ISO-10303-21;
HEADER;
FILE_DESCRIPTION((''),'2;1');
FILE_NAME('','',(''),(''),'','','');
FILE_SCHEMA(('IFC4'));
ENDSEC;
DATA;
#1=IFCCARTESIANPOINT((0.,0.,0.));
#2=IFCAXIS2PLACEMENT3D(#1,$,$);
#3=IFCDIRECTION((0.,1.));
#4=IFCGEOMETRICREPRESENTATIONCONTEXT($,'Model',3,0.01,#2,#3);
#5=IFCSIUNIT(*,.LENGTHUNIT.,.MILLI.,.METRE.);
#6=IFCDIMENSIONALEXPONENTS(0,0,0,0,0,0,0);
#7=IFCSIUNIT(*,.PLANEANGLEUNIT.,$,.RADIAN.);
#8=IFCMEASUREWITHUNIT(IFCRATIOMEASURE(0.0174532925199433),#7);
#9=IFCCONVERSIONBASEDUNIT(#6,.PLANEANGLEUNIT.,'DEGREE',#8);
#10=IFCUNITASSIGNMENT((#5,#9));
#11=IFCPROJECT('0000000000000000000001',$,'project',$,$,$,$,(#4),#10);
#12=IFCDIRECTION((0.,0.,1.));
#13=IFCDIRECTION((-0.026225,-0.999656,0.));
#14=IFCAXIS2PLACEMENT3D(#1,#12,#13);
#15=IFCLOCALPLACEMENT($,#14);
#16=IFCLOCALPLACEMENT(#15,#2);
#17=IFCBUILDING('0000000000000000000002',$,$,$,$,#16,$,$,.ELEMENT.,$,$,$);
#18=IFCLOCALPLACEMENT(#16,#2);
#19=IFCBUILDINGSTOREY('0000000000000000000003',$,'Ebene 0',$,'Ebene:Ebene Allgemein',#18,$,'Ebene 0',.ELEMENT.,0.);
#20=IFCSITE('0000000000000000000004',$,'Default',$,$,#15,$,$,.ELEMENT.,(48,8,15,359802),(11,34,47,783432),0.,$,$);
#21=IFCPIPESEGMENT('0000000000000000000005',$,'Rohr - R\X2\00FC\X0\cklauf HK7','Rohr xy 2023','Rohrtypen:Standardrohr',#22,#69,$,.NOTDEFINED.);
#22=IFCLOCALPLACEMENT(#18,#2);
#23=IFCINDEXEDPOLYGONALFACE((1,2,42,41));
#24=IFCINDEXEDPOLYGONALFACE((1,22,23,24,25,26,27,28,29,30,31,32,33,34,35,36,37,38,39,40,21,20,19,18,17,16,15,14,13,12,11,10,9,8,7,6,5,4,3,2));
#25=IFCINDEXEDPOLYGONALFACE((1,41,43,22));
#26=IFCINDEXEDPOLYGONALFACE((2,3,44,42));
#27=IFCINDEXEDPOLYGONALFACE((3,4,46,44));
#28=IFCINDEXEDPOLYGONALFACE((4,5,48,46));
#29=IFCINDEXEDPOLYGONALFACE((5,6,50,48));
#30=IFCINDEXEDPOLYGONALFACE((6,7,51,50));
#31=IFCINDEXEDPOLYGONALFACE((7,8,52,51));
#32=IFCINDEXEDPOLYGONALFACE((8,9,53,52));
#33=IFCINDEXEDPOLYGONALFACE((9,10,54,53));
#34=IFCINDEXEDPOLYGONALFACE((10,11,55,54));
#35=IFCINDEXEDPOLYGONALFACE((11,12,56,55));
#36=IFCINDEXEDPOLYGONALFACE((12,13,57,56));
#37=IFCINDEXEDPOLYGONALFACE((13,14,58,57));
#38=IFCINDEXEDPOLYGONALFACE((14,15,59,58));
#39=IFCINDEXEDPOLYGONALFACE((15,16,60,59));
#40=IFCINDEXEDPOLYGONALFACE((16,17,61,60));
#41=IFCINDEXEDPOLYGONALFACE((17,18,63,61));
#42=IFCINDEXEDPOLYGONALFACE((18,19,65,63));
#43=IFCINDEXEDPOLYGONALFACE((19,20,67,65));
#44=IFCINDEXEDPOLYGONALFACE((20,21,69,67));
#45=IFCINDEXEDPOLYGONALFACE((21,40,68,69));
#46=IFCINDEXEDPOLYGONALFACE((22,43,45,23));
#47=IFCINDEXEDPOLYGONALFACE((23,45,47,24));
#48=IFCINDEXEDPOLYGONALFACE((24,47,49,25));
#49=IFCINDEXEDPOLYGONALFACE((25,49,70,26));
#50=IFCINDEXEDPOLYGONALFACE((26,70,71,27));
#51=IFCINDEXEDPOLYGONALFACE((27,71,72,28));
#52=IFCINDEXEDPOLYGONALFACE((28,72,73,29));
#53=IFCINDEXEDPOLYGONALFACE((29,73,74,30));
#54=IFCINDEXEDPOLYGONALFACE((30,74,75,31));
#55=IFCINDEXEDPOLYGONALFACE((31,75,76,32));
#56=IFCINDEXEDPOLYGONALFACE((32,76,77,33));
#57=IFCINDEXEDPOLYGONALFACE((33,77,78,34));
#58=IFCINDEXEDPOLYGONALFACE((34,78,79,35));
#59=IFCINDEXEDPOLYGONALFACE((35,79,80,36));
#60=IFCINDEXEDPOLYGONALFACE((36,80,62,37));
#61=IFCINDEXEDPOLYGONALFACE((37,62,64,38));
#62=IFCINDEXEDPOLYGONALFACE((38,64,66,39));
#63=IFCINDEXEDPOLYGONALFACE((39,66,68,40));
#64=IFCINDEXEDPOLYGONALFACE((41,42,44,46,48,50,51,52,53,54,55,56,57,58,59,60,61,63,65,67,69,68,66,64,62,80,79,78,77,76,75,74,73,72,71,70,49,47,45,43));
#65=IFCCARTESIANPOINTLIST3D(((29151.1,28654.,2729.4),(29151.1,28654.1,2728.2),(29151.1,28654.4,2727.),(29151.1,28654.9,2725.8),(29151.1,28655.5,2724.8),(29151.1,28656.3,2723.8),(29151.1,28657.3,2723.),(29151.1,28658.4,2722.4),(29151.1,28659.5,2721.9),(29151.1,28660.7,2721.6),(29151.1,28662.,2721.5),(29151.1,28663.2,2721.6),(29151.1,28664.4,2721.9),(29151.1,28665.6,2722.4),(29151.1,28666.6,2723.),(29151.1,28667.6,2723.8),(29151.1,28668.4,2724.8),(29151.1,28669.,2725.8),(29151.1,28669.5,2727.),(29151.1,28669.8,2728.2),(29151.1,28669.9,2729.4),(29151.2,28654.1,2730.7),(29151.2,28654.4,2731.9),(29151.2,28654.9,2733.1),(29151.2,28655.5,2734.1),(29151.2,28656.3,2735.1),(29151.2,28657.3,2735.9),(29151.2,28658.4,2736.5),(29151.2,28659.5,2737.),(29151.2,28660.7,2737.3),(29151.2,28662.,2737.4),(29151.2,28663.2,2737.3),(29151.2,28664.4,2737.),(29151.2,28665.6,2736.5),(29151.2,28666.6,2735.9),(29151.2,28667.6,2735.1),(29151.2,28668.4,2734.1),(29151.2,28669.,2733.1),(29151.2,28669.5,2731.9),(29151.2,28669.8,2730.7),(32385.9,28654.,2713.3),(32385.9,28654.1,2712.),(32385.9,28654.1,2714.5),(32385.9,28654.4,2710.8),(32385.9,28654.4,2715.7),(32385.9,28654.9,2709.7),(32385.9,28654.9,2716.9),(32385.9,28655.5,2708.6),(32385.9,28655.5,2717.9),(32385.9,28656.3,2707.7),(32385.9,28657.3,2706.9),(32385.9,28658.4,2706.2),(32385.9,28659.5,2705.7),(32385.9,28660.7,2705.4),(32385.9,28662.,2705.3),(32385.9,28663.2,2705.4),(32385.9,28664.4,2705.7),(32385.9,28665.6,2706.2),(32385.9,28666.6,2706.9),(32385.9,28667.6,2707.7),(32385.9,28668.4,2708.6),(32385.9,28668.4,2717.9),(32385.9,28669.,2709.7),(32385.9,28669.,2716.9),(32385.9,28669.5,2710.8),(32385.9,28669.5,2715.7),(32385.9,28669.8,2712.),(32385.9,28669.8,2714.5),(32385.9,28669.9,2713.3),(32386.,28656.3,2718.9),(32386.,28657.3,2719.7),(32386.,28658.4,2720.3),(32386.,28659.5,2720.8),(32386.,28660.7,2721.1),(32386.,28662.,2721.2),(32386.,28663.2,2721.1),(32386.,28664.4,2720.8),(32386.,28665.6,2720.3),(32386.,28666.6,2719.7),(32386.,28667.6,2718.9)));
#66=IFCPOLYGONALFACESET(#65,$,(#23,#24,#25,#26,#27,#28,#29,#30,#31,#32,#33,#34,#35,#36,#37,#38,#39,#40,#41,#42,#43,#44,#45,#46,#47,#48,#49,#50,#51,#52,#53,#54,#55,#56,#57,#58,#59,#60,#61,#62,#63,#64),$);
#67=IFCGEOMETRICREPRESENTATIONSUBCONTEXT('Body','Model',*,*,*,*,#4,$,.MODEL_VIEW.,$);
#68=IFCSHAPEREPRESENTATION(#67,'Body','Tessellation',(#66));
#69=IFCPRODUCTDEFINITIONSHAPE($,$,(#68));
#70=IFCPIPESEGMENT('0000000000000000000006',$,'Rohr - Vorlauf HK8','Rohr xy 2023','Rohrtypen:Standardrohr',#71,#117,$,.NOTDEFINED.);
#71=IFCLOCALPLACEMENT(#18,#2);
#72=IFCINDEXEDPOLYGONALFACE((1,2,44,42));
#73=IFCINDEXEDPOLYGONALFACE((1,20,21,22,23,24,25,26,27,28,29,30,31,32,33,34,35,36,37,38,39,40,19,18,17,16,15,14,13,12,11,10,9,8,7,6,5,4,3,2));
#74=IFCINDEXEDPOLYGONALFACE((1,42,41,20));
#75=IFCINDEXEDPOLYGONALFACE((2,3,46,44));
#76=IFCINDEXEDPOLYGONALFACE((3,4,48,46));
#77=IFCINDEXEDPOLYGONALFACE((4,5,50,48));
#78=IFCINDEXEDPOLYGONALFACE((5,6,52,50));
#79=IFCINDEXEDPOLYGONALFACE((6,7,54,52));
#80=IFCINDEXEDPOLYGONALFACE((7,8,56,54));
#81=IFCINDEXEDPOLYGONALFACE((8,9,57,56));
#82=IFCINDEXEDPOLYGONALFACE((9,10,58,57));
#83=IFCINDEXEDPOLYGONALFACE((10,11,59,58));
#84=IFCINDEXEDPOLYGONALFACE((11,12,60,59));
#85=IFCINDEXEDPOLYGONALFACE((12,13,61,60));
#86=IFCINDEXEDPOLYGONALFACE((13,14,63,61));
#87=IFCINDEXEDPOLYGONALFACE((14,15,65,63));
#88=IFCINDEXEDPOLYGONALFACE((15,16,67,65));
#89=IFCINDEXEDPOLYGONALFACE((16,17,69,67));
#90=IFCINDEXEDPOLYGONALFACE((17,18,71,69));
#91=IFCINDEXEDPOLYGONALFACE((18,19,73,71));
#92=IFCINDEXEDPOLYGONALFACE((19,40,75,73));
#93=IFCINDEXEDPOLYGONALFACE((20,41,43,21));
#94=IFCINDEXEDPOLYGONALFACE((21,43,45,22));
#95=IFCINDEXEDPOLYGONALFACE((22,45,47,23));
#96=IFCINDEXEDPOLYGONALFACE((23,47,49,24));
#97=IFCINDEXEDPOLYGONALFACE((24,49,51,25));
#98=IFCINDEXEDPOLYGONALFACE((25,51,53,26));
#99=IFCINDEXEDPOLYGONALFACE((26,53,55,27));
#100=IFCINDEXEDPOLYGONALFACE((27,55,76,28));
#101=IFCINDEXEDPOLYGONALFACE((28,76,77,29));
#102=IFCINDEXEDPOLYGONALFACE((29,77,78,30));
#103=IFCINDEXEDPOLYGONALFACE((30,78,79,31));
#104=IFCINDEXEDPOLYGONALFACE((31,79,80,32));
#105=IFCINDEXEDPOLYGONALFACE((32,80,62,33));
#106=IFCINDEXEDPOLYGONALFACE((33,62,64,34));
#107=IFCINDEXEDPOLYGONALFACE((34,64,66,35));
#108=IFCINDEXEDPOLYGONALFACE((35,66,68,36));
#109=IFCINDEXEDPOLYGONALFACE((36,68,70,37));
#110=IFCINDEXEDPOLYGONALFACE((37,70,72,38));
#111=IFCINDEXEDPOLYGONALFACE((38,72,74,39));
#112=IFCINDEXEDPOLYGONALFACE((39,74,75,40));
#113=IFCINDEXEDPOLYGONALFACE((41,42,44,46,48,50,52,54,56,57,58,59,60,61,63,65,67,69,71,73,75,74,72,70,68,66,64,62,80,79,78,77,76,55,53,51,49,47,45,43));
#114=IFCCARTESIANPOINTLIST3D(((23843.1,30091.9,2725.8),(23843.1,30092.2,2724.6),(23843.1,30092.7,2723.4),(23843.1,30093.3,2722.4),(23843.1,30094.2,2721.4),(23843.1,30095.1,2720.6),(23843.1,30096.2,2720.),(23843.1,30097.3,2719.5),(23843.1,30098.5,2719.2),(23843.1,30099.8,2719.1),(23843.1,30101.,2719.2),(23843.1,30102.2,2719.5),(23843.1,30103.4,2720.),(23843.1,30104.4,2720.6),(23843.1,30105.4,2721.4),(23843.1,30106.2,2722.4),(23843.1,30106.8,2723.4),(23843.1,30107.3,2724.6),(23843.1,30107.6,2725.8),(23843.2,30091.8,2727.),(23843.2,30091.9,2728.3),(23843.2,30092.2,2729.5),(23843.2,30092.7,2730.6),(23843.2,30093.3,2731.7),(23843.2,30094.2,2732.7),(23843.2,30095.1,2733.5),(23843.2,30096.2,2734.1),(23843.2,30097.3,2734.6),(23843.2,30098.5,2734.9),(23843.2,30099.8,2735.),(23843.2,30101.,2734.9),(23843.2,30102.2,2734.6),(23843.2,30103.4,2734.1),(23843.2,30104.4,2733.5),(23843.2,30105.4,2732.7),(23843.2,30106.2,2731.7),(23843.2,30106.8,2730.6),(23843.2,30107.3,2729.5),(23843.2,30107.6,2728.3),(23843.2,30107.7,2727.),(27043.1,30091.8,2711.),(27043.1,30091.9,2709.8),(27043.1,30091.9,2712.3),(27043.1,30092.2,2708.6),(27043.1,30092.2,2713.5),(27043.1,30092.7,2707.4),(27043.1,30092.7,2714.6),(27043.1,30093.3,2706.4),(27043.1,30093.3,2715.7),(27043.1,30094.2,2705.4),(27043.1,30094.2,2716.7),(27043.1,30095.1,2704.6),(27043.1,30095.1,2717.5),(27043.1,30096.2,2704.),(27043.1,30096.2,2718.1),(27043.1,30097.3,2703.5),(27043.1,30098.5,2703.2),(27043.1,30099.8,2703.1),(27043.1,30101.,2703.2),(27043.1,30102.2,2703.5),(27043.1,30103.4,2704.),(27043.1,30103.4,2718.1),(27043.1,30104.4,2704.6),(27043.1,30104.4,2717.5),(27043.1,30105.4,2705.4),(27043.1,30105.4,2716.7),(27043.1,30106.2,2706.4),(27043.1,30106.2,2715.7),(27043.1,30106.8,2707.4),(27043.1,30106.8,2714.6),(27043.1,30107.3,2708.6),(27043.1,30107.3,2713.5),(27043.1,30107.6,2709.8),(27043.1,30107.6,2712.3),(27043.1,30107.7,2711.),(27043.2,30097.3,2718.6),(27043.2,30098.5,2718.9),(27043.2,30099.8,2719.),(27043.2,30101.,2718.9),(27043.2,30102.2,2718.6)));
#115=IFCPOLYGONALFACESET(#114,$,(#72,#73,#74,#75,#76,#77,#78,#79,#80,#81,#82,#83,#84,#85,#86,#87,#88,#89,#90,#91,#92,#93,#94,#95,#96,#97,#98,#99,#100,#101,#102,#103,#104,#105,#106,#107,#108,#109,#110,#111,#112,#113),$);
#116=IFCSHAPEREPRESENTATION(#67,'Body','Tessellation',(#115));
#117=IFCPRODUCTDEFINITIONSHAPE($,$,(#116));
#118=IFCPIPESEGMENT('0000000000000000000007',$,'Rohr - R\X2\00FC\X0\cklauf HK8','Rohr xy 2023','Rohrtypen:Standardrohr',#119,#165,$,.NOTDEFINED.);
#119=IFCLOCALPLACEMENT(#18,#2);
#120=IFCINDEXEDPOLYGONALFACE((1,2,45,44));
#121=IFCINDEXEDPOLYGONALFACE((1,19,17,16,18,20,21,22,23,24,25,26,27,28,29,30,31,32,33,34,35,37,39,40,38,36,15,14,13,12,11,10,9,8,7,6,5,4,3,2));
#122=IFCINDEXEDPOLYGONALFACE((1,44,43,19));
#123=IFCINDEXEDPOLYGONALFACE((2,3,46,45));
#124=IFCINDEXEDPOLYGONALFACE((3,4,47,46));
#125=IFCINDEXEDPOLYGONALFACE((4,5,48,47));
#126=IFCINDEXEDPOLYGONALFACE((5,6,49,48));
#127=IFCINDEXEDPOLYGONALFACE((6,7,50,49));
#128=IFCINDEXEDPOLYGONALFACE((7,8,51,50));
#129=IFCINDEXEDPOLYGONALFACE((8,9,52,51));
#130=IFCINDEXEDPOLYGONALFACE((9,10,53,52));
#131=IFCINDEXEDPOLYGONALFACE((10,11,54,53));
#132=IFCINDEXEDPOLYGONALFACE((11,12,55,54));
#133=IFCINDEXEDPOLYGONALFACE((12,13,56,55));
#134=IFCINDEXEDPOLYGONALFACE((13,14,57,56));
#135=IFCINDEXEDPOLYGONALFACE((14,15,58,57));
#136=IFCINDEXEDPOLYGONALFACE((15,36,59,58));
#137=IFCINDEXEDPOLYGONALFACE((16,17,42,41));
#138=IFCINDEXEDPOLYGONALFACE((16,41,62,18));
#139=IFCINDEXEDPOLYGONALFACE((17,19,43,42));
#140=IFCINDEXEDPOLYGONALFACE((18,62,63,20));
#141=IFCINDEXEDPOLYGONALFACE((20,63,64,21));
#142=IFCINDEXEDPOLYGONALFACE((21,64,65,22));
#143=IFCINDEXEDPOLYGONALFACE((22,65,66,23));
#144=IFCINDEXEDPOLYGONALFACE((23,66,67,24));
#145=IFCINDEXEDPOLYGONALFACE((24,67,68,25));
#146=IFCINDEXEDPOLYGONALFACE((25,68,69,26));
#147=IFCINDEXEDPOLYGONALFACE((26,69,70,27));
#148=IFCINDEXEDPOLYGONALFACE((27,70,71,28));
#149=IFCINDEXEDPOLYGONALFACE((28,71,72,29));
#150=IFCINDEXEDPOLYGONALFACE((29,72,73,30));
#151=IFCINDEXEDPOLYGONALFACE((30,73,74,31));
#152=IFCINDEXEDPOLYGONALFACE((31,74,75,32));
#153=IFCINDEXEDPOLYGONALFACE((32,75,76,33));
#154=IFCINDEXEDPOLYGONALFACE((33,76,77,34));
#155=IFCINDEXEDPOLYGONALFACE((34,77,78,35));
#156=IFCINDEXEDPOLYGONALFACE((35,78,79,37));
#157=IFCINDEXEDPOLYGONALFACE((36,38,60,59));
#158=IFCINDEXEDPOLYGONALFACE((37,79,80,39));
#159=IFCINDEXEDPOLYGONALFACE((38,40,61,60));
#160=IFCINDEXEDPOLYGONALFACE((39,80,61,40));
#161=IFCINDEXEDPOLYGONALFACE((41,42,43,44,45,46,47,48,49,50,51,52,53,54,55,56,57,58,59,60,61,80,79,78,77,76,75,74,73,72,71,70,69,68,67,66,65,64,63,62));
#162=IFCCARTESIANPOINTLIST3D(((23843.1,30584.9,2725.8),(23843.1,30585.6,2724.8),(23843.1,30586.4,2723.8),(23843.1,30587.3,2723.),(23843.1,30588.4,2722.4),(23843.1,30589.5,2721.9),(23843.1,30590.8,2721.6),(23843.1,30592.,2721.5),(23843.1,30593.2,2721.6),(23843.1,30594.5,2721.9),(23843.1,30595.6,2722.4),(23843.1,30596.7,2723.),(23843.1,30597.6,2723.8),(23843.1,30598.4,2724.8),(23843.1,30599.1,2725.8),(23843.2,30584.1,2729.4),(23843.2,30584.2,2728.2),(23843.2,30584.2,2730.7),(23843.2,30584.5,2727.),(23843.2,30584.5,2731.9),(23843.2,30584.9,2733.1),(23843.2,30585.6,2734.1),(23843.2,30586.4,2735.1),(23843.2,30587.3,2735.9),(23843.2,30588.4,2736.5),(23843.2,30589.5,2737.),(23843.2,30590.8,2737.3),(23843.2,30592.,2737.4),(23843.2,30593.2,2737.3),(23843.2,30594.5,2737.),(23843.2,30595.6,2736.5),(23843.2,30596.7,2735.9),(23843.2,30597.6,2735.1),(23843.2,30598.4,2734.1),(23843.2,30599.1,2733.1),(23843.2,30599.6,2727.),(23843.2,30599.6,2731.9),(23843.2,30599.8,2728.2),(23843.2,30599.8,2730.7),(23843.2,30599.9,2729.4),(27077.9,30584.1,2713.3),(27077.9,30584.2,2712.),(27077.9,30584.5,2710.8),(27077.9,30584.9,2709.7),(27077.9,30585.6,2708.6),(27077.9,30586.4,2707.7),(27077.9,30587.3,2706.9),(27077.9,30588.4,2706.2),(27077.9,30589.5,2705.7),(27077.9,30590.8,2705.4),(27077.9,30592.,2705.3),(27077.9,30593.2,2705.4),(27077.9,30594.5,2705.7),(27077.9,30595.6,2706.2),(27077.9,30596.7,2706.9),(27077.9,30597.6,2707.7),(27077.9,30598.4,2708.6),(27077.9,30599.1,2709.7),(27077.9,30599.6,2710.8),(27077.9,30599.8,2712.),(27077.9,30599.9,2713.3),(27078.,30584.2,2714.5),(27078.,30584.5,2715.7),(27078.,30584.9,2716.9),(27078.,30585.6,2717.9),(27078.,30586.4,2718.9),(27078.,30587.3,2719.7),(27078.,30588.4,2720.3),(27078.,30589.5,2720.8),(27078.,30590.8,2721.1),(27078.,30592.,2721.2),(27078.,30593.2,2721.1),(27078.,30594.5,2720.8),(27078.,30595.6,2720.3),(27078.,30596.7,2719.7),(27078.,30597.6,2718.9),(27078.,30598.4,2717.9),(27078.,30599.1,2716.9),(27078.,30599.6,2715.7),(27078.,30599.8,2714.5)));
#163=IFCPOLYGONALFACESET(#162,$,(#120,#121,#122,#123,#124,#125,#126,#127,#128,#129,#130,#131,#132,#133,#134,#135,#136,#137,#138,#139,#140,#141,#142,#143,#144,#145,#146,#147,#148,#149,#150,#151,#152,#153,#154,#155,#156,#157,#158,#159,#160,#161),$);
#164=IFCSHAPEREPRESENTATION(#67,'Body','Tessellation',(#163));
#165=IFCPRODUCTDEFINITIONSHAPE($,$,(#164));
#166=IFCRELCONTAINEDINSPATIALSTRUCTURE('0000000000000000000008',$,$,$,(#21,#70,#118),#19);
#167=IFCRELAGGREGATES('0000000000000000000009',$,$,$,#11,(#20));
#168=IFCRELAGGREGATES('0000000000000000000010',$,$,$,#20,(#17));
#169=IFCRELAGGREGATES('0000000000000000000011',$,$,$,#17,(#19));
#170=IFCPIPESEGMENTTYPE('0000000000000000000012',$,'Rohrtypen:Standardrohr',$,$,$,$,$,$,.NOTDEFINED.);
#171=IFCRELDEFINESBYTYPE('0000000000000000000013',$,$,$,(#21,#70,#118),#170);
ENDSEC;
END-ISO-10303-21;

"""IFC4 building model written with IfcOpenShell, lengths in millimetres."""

from ifc_helpers import new_model, entity, si_unit, converted_unit, direction, frame, origin, place, context, subcontext, project, spatial, indexed_curve, outline, extrude, type_object, element, save


model = new_model("IFC4")

# Units and contexts
model_context = context("Model", 3, precision=0.01, world=origin(), true_north=direction((0.0, 1.0)))
body_context = subcontext(model_context, "Body", "Model", "MODEL_VIEW")
ifc_project = project(units=[si_unit("LENGTHUNIT", "METRE", prefix="MILLI"), converted_unit("PLANEANGLEUNIT", "DEGREE", entity("IfcRatioMeasure", 0.0174532925199433), si_unit("PLANEANGLEUNIT", "RADIAN"), dimensions=[0, 0, 0, 0, 0, 0, 0])], contexts=[model_context])

# Site, building, storey
site_placement = place(None, frame((0.0, 0.0, 0.0), z_axis=(0.0, 0.0, 1.0), x_axis=(-0.026225, -0.999656, 0.0)))
site = spatial("IfcSite", under=ifc_project, at=site_placement, Name="Default", CompositionType="ELEMENT", RefLatitude=(48, 8, 15, 359802), RefLongitude=(11, 34, 47, 783432), RefElevation=0.0)
building_placement = place(site_placement, origin())
building = spatial("IfcBuilding", under=site, at=building_placement, CompositionType="ELEMENT")
storey_placement = place(building_placement, origin())
storey = spatial("IfcBuildingStorey", under=building, at=storey_placement, Name="Ebene 0", ObjectType="Ebene:Ebene Allgemein", LongName="Ebene 0", CompositionType="ELEMENT", Elevation=0.0)

# Pipe segments
pipe_segment_type = type_object("IfcPipeSegmentType", Name="Rohrtypen:Standardrohr", PredefinedType="NOTDEFINED")
pipe_segment_1_placement = place(storey_placement, origin())
element("IfcPipeSegment", 1, at=pipe_segment_1_placement, inside=storey, type_object=pipe_segment_type, Name="Rohr - Rücklauf HK7", Description="Rohr xy 2023", ObjectType="Rohrtypen:Standardrohr", PredefinedType="NOTDEFINED", context=body_context, shape_type="SweptSolid", body=[
    extrude(outline(indexed_curve([(7.9, 0.0), (7.8, 1.2), (7.6, 2.5), (7.1, 3.6), (6.4, 4.7), (5.6, 5.6), (4.7, 6.4), (3.6, 7.1), (2.5, 7.6), (1.2, 7.8), (0.0, 7.9), (-1.2, 7.8), (-2.5, 7.6), (-3.6, 7.1), (-4.7, 6.4), (-5.6, 5.6), (-6.4, 4.7), (-7.1, 3.6), (-7.6, 2.5), (-7.8, 1.2), (-7.9, 0.0), (-7.8, -1.2), (-7.6, -2.5), (-7.1, -3.6), (-6.4, -4.7), (-5.6, -5.6), (-4.7, -6.4), (-3.6, -7.1), (-2.5, -7.6), (-1.2, -7.8), (0.0, -7.9), (1.2, -7.8), (2.5, -7.6), (3.6, -7.1), (4.7, -6.4), (5.6, -5.6), (6.4, -4.7), (7.1, -3.6), (7.6, -2.5), (7.8, -1.2), (7.9, 0.0)], self_intersect=False)), frame((32385.9, 28662.0, 2713.3), z_axis=(-0.999988, 0.0, 0.005), x_axis=(0.0, 1.0, 0.0)), (0.0, 0.0, 1.0), 3234.8),
])
pipe_segment_2_placement = place(storey_placement, origin())
element("IfcPipeSegment", 2, at=pipe_segment_2_placement, inside=storey, type_object=pipe_segment_type, Name="Rohr - Vorlauf HK8", Description="Rohr xy 2023", ObjectType="Rohrtypen:Standardrohr", PredefinedType="NOTDEFINED", context=body_context, shape_type="SweptSolid", body=[
    extrude(outline(indexed_curve([(7.9, 0.0), (7.8, 1.2), (7.6, 2.5), (7.1, 3.6), (6.4, 4.7), (5.6, 5.6), (4.7, 6.4), (3.6, 7.1), (2.5, 7.6), (1.2, 7.8), (0.0, 7.9), (-1.2, 7.8), (-2.5, 7.6), (-3.6, 7.1), (-4.7, 6.4), (-5.6, 5.6), (-6.4, 4.7), (-7.1, 3.6), (-7.6, 2.5), (-7.8, 1.2), (-7.9, 0.0), (-7.8, -1.2), (-7.6, -2.5), (-7.1, -3.6), (-6.4, -4.7), (-5.6, -5.6), (-4.7, -6.4), (-3.6, -7.1), (-2.5, -7.6), (-1.2, -7.8), (0.0, -7.9), (1.2, -7.8), (2.5, -7.6), (3.6, -7.1), (4.7, -6.4), (5.6, -5.6), (6.4, -4.7), (7.1, -3.6), (7.6, -2.5), (7.8, -1.2), (7.9, 0.0)], self_intersect=False)), frame((27043.1, 30099.8, 2711.0), z_axis=(-0.999988, 0.0, 0.005), x_axis=(0.0, 1.0, 0.0)), (0.0, 0.0, 1.0), 3200.0),
])
pipe_segment_3_placement = place(storey_placement, origin())
element("IfcPipeSegment", 3, at=pipe_segment_3_placement, inside=storey, type_object=pipe_segment_type, Name="Rohr - Rücklauf HK8", Description="Rohr xy 2023", ObjectType="Rohrtypen:Standardrohr", PredefinedType="NOTDEFINED", context=body_context, shape_type="SweptSolid", body=[
    extrude(outline(indexed_curve([(7.9, 0.0), (7.8, 1.2), (7.6, 2.5), (7.1, 3.6), (6.4, 4.7), (5.6, 5.6), (4.7, 6.4), (3.6, 7.1), (2.5, 7.6), (1.2, 7.8), (0.0, 7.9), (-1.2, 7.8), (-2.5, 7.6), (-3.6, 7.1), (-4.7, 6.4), (-5.6, 5.6), (-6.4, 4.7), (-7.1, 3.6), (-7.6, 2.5), (-7.8, 1.2), (-7.9, 0.0), (-7.8, -1.2), (-7.6, -2.5), (-7.1, -3.6), (-6.4, -4.7), (-5.6, -5.6), (-4.7, -6.4), (-3.6, -7.1), (-2.5, -7.6), (-1.2, -7.8), (0.0, -7.9), (1.2, -7.8), (2.5, -7.6), (3.6, -7.1), (4.7, -6.4), (5.6, -5.6), (6.4, -4.7), (7.1, -3.6), (7.6, -2.5), (7.8, -1.2), (7.9, 0.0)], self_intersect=False)), frame((27077.9, 30592.0, 2713.3), z_axis=(-0.999988, 0.0, 0.005), x_axis=(0.0, 1.0, 0.0)), (0.0, 0.0, 1.0), 3234.8),
])

save(model, "model.ifc")
